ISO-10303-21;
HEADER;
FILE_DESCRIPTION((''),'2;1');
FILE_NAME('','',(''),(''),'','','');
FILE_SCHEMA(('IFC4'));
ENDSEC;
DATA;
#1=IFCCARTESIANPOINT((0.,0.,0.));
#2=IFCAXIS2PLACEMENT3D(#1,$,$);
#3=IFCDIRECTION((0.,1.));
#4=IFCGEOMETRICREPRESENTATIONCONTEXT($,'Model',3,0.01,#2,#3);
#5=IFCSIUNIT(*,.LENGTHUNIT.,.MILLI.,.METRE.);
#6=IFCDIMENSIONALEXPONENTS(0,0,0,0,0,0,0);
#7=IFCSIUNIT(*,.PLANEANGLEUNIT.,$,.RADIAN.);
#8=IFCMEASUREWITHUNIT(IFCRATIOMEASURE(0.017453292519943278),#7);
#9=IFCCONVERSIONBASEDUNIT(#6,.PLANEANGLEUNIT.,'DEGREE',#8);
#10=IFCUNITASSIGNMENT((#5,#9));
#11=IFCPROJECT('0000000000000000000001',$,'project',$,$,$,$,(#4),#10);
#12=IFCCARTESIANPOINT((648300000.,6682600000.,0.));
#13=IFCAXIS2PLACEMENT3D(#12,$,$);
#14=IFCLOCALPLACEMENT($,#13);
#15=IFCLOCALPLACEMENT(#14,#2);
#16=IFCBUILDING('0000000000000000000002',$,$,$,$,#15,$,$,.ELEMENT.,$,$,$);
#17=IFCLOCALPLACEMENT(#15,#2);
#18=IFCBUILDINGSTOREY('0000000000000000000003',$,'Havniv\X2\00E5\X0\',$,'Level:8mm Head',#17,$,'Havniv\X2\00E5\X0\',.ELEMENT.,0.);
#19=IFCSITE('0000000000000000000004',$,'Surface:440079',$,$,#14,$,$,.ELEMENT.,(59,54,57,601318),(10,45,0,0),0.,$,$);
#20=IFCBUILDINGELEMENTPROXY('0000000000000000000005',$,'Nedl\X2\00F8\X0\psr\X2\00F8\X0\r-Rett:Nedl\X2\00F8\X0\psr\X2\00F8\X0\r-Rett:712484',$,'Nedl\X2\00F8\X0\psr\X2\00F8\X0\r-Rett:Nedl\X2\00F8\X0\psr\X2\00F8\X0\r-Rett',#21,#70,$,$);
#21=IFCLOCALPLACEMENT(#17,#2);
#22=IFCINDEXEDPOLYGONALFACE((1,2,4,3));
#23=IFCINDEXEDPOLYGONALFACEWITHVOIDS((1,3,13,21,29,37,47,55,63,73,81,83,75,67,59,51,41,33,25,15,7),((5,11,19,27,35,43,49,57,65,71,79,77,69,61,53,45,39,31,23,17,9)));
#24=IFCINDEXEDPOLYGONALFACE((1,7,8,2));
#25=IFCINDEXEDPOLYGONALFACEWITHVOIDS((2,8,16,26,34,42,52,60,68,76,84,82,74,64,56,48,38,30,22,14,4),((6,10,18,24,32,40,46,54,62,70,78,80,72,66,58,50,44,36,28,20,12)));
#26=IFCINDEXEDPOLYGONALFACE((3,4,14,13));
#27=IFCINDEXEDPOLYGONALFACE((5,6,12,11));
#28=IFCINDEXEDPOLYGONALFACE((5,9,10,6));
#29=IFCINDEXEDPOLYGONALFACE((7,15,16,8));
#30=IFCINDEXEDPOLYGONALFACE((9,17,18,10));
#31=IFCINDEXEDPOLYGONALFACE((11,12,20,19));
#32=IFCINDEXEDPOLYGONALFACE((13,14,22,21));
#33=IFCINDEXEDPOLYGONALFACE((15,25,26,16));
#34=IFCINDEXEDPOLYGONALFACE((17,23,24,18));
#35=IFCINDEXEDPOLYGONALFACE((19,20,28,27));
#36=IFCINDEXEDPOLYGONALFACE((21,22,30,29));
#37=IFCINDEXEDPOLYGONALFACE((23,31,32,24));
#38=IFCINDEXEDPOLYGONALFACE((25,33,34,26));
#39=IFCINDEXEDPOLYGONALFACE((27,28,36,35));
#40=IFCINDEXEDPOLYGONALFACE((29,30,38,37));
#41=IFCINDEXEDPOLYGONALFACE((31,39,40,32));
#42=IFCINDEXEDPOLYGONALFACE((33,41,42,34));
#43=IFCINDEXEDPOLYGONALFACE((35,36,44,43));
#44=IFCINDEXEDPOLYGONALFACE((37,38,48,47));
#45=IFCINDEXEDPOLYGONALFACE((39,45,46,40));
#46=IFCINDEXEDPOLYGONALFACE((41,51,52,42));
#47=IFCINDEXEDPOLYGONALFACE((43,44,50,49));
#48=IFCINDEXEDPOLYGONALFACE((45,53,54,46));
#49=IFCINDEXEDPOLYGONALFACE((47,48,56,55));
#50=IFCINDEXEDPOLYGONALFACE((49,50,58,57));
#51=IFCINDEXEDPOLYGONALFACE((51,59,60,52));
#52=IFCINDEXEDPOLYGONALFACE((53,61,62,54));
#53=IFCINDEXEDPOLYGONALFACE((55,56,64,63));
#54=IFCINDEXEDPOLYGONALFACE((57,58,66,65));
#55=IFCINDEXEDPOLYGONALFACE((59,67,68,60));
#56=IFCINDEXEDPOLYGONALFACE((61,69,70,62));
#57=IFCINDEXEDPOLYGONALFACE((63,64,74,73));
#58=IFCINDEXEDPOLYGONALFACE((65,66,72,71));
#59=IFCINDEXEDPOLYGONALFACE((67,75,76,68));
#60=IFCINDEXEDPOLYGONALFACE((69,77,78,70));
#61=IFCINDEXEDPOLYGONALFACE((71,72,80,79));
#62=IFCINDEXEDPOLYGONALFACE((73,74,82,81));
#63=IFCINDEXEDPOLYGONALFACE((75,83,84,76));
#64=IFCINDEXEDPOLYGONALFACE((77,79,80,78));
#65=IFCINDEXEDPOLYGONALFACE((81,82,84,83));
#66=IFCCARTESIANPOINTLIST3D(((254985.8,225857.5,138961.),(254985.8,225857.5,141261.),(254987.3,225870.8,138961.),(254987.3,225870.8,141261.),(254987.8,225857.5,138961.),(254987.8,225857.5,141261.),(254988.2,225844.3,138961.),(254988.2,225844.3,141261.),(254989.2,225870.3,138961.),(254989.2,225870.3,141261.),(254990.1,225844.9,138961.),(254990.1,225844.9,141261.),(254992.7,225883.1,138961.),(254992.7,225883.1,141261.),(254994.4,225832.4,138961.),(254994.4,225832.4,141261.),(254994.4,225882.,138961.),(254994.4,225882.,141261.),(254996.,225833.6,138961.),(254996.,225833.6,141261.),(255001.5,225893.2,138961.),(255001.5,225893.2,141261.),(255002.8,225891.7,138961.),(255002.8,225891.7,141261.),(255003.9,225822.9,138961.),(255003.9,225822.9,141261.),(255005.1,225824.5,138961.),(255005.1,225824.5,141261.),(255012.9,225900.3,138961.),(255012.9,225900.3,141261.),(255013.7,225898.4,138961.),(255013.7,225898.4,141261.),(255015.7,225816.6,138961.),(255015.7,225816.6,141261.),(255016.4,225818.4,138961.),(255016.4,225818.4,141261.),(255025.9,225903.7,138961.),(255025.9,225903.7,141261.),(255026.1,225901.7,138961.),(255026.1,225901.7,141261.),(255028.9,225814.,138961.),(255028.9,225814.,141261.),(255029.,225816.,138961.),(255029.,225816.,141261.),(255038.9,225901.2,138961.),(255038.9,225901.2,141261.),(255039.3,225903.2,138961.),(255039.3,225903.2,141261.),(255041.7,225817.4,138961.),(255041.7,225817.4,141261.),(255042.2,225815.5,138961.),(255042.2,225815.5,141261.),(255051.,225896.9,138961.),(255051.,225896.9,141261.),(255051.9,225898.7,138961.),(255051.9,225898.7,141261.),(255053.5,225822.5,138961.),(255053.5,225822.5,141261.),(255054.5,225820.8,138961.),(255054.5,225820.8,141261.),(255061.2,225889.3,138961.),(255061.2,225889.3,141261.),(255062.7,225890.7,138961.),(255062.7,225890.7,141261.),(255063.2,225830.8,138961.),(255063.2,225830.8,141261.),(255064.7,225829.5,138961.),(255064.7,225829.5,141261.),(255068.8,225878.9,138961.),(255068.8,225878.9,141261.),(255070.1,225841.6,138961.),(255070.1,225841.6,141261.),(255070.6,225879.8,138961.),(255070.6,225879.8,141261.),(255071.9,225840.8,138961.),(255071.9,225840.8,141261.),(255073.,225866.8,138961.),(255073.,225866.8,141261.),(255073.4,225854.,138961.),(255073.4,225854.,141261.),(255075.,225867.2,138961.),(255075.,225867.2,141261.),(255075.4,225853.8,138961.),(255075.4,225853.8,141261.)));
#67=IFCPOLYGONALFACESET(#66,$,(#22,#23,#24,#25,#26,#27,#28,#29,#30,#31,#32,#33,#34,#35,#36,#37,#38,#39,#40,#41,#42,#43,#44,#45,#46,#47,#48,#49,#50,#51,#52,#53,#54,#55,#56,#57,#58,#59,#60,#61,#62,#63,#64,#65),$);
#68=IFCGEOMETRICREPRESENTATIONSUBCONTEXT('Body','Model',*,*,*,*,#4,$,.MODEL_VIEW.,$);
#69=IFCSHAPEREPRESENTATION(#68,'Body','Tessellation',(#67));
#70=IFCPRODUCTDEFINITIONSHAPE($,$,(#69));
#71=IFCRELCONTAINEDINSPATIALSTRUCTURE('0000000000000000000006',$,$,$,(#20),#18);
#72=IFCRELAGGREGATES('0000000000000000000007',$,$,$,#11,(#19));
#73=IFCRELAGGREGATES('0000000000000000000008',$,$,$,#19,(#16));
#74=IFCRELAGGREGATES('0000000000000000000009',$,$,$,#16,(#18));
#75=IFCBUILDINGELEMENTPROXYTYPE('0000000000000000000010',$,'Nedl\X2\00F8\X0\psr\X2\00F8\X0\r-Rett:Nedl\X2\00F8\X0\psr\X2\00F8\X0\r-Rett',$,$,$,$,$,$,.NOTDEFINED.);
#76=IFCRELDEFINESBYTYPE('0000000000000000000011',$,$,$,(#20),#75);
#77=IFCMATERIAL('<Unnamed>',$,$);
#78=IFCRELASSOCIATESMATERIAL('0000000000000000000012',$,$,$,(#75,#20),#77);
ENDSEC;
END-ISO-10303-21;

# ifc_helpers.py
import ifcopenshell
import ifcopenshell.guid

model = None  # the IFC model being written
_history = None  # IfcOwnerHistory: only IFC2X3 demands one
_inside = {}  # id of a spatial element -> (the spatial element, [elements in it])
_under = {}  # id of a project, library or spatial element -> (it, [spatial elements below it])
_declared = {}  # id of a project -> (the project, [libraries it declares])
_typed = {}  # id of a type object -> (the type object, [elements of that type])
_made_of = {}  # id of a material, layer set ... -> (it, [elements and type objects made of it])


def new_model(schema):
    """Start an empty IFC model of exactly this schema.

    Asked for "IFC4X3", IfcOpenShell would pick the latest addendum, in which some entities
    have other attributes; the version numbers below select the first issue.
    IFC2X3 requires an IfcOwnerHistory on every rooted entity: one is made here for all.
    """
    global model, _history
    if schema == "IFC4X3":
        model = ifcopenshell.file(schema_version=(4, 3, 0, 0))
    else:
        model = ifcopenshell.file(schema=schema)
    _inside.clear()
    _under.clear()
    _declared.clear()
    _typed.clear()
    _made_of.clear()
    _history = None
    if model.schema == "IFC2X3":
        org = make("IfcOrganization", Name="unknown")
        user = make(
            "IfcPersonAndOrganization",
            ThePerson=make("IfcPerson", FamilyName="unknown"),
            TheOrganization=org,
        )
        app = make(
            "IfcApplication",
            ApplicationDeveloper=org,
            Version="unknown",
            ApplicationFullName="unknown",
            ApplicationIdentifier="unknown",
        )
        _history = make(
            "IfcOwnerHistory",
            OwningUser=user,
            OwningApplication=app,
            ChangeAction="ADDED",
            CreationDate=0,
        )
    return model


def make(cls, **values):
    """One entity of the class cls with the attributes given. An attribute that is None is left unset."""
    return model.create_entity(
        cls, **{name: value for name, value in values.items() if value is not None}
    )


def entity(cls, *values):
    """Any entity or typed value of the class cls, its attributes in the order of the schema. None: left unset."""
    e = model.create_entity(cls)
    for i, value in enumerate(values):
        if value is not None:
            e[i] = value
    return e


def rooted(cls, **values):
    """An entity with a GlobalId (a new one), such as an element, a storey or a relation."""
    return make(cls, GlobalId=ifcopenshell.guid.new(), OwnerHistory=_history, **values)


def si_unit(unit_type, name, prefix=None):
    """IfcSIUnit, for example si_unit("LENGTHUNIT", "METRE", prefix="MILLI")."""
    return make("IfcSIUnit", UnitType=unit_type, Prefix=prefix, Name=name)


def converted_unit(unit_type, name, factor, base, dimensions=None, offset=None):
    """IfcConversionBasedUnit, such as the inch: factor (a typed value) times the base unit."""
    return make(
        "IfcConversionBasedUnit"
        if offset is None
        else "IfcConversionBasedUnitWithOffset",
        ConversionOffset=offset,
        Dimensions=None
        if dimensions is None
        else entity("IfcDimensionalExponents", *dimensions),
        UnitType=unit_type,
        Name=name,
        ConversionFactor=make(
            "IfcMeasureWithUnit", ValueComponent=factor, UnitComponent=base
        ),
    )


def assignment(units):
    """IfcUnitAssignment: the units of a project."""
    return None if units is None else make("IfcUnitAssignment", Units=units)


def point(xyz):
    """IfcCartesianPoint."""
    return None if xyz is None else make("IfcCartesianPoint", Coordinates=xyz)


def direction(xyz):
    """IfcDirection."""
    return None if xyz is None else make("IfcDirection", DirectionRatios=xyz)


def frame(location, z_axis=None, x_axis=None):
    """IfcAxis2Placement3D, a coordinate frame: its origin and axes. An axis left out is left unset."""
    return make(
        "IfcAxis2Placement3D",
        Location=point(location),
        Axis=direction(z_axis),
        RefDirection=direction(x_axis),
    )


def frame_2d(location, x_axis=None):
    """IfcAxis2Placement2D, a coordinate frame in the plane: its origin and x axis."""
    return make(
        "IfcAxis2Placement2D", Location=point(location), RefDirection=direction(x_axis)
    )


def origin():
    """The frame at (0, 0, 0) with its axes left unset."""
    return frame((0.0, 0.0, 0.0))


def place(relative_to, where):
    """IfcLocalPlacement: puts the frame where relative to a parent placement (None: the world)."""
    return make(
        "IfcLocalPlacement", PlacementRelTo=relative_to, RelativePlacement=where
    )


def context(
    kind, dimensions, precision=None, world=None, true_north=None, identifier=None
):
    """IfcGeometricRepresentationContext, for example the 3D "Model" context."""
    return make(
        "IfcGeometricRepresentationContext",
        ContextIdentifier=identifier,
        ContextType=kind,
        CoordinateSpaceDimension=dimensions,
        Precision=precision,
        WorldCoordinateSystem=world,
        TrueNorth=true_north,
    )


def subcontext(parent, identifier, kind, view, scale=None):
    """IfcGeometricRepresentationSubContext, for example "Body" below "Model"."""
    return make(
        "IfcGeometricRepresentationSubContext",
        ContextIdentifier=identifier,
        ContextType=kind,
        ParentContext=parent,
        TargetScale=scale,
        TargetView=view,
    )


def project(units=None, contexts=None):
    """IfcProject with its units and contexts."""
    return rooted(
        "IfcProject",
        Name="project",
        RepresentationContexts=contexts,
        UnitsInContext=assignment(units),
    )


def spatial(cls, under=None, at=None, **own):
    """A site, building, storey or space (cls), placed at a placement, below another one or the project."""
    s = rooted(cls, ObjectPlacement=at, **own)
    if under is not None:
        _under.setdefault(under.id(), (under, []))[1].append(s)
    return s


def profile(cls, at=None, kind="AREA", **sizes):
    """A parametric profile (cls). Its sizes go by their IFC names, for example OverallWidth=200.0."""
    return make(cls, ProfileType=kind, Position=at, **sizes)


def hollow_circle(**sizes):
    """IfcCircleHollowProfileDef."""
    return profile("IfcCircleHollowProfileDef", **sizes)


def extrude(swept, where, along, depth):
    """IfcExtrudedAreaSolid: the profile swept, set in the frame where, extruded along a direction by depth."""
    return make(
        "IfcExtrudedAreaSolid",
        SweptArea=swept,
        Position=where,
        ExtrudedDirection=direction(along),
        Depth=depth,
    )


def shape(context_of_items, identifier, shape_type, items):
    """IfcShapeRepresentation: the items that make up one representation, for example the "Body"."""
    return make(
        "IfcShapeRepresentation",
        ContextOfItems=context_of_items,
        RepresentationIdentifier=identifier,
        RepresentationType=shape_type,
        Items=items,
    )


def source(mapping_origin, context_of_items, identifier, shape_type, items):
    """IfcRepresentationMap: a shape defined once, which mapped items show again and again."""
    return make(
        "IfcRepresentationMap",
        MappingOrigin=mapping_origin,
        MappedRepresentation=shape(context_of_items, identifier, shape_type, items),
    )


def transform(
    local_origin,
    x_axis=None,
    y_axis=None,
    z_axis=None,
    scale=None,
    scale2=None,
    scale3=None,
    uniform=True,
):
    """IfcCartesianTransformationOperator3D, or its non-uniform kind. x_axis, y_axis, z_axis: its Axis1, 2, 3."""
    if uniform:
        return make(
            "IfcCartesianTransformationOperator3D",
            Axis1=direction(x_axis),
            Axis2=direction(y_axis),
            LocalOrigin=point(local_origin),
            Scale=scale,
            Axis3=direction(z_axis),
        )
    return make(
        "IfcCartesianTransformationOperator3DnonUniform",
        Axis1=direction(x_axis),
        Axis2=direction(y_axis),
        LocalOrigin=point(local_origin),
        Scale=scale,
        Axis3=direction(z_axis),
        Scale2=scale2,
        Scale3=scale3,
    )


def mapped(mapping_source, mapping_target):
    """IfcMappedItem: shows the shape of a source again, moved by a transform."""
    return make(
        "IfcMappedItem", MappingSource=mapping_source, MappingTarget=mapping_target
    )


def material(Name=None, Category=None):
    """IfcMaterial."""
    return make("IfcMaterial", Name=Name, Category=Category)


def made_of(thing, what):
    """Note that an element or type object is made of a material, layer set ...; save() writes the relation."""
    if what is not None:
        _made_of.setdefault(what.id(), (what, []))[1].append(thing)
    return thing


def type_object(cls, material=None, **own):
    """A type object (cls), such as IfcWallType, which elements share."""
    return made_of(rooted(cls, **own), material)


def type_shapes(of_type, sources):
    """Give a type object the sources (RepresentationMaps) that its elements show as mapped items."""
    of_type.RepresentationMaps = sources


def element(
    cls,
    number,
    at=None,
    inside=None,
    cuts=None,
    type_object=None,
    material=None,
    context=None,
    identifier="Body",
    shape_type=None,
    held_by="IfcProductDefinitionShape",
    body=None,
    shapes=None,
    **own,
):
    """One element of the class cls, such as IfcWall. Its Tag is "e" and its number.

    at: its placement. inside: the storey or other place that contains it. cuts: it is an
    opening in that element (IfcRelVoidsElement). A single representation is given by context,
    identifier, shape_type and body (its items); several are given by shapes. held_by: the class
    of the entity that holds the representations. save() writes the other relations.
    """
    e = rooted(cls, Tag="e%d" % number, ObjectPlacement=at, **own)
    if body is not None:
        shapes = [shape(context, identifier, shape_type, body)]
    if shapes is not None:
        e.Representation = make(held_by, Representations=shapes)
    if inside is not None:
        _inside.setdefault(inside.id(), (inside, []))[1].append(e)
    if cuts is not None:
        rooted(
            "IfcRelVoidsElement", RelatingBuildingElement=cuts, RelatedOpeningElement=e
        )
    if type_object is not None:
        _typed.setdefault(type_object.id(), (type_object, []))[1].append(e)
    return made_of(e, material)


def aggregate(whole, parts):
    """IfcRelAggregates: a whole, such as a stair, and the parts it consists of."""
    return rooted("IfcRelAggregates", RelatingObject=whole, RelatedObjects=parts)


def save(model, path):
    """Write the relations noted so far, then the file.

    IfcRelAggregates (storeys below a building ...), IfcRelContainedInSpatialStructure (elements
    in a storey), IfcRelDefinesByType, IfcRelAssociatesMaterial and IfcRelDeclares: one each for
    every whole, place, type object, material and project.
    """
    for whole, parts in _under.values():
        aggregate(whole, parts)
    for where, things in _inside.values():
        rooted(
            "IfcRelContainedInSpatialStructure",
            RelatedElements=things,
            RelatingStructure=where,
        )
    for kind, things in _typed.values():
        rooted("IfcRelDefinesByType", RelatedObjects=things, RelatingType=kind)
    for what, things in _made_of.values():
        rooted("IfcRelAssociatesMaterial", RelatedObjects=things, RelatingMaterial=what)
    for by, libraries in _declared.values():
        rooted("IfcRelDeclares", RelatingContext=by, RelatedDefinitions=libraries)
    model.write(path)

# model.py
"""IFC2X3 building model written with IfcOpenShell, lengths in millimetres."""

from ifc_helpers import new_model, entity, si_unit, converted_unit, direction, frame, frame_2d, origin, place, context, subcontext, project, spatial, hollow_circle, extrude, source, transform, mapped, material, type_object, type_shapes, element, save


model = new_model("IFC2X3")

# Units and contexts
model_context = context("Model", 3, precision=0.01, world=origin(), true_north=direction((0.0, 1.0)))
body_context = subcontext(model_context, "Body", "Model", "MODEL_VIEW")
ifc_project = project(units=[si_unit("LENGTHUNIT", "METRE", prefix="MILLI"), converted_unit("PLANEANGLEUNIT", "DEGREE", entity("IfcRatioMeasure", 0.017453292519943278), si_unit("PLANEANGLEUNIT", "RADIAN"), dimensions=[0, 0, 0, 0, 0, 0, 0])], contexts=[model_context])

# Site, building, storey
site_placement = place(None, frame((648300000.0, 6682600000.0, 0.0)))
site = spatial("IfcSite", under=ifc_project, at=site_placement, Name="Surface:440079", CompositionType="ELEMENT", RefLatitude=(59, 54, 57, 601318), RefLongitude=(10, 45, 0, 0), RefElevation=0.0)
building_placement = place(site_placement, origin())
building = spatial("IfcBuilding", under=site, at=building_placement, CompositionType="ELEMENT")
storey_placement = place(building_placement, origin())
storey = spatial("IfcBuildingStorey", under=building, at=storey_placement, Name="Havnivå", ObjectType="Level:8mm Head", LongName="Havnivå", CompositionType="ELEMENT", Elevation=0.0)

# Building element proxy
ifc_material_1 = material(Name="<Unnamed>")
building_element_proxy_type_1 = type_object("IfcBuildingElementProxyType", Name="Nedløpsrør-Rett:Nedløpsrør-Rett", PredefinedType="NOTDEFINED", material=ifc_material_1)
shared_shape_1 = source(origin(), body_context, "Body", "SweptSolid", [
    extrude(hollow_circle(Radius=45.0, WallThickness=2.0, at=frame_2d((0.0, 0.0), x_axis=(1.0, 0.0))), frame((0.0, 0.0, 0.0), z_axis=(0.0, 0.0, 1.0), x_axis=(-1.0, 0.0, 0.0)), (0.0, 0.0, 1.0), 2300.0),
])
type_shapes(building_element_proxy_type_1, [shared_shape_1])
proxy_1_placement = place(storey_placement, frame((255030.7, 225859.0, 138961.0), z_axis=(0.0, 0.0, 1.0), x_axis=(-0.755467, 0.655187, 0.0)))
element("IfcBuildingElementProxy", 1, at=proxy_1_placement, inside=storey, type_object=building_element_proxy_type_1, material=ifc_material_1, Name="Nedløpsrør-Rett:Nedløpsrør-Rett:712484", ObjectType="Nedløpsrør-Rett:Nedløpsrør-Rett", context=body_context, shape_type="MappedRepresentation", body=[
    mapped(shared_shape_1, transform((0.0, 0.0, 0.0), scale=1.0)),
])

save(model, "model.ifc")
